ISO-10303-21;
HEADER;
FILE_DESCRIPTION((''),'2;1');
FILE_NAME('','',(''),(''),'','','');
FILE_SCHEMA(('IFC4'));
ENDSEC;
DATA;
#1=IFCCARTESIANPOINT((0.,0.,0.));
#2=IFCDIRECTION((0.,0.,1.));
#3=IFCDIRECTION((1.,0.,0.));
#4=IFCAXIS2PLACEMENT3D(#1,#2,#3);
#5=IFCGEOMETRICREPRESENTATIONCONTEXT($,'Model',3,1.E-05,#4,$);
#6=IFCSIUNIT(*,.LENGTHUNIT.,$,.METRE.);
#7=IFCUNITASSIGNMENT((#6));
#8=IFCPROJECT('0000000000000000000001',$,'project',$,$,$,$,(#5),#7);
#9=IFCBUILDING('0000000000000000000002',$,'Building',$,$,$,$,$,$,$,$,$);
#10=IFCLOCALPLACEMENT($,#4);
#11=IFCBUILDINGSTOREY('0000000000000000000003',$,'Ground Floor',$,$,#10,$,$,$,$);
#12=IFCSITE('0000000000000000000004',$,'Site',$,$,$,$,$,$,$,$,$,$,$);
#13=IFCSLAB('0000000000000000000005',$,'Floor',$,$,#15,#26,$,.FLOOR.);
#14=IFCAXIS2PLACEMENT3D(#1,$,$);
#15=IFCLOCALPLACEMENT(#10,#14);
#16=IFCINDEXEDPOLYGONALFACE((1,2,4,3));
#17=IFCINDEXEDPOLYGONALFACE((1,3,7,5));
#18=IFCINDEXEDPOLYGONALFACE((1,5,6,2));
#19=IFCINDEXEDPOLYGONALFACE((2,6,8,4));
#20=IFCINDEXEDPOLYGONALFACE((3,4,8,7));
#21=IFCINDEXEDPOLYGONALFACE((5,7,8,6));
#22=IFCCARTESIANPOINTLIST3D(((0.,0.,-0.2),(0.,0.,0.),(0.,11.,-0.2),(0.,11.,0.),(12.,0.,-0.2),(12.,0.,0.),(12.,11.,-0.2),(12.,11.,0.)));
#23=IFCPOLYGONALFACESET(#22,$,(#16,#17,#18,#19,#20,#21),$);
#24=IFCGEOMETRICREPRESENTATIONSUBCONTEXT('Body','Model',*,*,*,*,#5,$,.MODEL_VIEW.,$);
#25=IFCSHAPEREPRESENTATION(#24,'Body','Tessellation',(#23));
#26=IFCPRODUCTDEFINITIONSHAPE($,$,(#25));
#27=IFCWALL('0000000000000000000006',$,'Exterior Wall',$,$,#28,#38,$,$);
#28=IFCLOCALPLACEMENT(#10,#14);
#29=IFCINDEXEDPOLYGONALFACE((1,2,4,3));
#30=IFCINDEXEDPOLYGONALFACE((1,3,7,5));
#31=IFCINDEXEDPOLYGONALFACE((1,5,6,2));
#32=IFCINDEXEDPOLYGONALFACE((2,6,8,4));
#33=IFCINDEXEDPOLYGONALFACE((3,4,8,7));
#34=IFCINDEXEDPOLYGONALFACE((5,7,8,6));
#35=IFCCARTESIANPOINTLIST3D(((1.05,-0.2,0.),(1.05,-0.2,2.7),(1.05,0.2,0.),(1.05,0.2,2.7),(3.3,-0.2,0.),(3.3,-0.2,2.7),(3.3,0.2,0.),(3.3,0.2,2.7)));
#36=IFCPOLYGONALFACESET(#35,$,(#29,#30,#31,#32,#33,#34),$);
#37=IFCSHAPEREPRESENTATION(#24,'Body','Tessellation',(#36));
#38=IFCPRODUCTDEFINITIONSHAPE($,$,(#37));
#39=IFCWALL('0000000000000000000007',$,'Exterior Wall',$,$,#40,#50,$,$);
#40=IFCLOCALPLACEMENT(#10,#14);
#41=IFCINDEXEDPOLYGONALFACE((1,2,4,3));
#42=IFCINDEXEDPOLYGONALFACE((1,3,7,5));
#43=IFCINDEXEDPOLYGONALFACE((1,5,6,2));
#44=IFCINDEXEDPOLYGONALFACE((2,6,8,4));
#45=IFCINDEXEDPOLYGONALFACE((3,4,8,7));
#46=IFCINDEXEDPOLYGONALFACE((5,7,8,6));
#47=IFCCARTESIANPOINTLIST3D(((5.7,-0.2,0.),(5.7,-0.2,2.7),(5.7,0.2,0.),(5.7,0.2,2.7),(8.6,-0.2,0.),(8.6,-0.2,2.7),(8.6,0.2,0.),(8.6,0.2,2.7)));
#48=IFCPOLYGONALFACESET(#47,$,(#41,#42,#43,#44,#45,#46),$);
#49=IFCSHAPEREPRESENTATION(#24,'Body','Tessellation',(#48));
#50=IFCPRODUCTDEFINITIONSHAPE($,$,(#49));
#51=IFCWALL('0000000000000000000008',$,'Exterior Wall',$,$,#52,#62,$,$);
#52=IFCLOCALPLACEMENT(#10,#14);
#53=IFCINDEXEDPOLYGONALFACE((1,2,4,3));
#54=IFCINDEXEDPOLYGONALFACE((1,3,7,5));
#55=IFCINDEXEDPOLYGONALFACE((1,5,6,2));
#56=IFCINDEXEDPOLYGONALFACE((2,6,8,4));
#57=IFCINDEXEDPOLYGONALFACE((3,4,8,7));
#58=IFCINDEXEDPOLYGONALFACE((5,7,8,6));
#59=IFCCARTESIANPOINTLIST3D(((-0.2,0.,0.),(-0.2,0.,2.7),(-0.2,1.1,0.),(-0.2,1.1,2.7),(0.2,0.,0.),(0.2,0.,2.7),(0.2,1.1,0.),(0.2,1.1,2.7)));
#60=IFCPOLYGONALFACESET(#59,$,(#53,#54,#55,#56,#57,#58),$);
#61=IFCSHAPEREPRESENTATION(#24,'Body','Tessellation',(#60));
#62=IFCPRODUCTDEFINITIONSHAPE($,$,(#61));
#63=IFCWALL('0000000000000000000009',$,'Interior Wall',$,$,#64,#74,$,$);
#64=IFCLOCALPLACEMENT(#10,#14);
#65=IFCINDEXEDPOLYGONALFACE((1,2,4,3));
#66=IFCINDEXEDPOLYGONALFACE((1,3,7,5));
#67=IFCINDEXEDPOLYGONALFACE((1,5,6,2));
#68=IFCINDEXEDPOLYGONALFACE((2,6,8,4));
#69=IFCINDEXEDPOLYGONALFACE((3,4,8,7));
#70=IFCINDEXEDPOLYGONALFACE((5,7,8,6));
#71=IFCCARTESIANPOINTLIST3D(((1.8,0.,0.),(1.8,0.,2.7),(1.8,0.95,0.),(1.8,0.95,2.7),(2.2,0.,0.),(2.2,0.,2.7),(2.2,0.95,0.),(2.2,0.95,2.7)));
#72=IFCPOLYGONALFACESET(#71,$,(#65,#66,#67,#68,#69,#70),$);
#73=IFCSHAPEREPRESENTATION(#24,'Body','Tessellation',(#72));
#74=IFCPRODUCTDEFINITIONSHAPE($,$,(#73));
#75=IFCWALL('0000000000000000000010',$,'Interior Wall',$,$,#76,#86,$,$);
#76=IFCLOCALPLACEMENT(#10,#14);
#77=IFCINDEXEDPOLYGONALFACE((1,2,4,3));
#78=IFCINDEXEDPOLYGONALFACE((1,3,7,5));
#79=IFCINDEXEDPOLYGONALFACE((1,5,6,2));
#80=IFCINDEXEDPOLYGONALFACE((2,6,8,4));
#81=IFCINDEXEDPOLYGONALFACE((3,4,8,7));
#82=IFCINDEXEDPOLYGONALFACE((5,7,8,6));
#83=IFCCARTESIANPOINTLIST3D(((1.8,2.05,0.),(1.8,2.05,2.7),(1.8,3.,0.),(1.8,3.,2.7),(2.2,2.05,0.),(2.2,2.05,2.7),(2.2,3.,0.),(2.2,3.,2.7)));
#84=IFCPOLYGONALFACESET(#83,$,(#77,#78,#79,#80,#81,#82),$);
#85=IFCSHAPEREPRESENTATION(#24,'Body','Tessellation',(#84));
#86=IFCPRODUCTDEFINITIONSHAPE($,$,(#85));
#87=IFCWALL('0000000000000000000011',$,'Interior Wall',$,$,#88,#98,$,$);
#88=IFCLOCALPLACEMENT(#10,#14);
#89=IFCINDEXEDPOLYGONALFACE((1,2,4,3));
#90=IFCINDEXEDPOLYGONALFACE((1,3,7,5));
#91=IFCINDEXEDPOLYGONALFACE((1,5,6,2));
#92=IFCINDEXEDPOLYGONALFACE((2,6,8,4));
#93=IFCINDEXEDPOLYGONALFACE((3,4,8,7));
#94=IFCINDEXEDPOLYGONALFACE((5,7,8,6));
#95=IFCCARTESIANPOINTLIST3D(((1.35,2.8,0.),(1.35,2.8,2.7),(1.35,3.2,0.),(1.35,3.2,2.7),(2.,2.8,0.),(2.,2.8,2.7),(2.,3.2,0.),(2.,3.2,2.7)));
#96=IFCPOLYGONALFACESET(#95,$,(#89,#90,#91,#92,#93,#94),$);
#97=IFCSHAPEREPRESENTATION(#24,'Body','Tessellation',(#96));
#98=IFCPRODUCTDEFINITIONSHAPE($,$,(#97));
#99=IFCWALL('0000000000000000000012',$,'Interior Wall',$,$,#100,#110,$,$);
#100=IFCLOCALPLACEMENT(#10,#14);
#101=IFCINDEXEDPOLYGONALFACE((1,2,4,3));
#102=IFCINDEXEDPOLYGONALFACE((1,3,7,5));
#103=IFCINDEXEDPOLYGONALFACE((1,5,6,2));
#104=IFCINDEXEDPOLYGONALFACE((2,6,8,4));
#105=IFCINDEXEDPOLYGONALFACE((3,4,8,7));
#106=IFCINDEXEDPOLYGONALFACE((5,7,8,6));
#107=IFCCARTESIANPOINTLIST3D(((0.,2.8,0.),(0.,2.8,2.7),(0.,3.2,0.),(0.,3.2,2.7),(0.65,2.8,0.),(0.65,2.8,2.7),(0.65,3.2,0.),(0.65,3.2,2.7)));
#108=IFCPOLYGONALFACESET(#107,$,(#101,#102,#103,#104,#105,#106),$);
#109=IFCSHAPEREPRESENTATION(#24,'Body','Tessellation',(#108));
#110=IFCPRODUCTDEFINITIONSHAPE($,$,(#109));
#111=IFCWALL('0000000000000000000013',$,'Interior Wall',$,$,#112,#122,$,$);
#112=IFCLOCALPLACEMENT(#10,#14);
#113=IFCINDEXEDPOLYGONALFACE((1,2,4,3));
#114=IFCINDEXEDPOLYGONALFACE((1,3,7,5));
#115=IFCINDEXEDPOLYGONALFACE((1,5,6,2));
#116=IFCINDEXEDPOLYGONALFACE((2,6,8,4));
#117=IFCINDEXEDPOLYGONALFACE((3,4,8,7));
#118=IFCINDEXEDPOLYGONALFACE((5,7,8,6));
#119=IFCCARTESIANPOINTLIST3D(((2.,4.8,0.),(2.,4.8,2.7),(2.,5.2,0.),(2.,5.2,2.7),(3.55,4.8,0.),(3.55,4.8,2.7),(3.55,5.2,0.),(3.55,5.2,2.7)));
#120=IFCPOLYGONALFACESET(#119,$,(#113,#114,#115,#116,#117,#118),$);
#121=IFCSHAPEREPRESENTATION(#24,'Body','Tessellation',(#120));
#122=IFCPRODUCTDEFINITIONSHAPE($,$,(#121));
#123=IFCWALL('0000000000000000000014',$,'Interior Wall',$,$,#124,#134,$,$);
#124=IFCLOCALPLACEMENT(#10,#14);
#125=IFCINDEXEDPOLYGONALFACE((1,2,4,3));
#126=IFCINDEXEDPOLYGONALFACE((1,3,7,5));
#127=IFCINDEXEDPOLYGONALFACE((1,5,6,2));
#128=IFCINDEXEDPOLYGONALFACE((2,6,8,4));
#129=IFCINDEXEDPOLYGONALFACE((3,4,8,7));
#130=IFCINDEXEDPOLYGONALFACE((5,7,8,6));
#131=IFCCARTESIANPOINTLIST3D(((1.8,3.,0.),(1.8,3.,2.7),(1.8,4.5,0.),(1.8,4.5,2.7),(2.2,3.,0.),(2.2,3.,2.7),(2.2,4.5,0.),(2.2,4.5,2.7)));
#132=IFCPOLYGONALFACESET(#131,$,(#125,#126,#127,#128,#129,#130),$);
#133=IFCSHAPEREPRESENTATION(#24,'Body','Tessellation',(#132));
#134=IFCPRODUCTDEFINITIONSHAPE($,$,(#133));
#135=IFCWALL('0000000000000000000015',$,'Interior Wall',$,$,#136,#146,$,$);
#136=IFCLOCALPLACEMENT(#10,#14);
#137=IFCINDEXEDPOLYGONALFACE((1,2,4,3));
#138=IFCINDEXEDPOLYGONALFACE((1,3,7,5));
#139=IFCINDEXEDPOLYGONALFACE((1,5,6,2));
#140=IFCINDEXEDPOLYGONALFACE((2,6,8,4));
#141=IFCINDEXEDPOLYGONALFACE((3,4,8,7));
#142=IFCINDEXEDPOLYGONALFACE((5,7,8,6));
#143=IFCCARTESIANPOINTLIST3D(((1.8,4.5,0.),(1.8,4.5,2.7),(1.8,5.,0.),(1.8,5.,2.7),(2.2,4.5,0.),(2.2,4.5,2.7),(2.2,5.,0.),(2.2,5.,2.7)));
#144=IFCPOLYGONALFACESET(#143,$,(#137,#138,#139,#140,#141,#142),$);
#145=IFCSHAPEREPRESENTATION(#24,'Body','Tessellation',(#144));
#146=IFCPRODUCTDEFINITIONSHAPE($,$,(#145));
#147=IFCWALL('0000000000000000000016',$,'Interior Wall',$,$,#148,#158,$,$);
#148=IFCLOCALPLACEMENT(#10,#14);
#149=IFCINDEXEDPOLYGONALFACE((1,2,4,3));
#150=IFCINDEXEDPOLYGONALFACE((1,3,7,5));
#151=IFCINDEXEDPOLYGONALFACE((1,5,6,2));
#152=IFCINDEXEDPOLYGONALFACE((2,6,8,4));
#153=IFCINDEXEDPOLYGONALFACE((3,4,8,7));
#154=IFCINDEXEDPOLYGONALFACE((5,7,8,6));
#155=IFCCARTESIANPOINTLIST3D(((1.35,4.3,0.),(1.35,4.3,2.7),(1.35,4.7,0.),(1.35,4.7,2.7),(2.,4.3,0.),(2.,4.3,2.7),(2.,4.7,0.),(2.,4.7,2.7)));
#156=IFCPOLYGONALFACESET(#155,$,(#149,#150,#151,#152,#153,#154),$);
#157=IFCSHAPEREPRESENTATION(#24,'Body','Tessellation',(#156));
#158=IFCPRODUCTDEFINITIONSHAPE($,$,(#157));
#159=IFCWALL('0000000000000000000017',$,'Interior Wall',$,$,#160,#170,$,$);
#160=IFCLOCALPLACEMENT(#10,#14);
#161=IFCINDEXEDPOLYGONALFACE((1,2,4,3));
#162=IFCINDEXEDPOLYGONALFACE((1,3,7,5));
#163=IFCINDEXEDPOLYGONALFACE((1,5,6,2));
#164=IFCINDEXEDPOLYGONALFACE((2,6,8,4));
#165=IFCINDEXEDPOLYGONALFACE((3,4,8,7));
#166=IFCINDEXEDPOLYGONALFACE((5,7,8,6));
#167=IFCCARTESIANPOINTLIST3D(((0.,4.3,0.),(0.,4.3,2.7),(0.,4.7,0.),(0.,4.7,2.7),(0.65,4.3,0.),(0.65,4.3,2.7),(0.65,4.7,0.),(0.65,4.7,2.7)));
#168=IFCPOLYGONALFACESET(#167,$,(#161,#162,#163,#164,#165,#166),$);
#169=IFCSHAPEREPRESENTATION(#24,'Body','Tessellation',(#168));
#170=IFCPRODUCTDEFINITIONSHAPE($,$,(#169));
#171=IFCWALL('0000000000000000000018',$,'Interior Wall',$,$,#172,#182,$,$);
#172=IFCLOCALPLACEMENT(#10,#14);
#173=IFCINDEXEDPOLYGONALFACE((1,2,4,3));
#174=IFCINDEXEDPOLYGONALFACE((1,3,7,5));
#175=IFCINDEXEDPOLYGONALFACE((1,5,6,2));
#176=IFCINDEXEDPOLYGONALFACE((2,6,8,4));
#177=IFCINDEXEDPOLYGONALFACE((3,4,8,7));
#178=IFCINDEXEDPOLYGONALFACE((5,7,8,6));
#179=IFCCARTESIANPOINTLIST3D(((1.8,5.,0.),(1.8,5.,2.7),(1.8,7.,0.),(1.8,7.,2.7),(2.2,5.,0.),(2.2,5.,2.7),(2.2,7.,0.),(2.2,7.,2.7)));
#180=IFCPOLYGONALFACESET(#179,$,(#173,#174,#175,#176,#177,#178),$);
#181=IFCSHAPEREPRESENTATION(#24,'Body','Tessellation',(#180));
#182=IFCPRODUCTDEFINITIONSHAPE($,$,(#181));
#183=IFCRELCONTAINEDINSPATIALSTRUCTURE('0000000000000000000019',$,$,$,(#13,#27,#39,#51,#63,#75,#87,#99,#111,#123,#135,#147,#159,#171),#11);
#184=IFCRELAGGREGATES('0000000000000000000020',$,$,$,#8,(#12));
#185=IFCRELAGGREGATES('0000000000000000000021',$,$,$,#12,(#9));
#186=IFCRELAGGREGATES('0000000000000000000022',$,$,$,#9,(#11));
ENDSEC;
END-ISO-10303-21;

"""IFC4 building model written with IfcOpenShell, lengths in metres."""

from ifc_helpers import new_model, si_unit, frame, origin_with_axes, place, context, subcontext, project, spatial, indexed_curve, outline, extrude, element, save


model = new_model("IFC4")

# Units and contexts
model_context = context("Model", 3, precision=1e-05, world=origin_with_axes())
body_context = subcontext(model_context, "Body", "Model", "MODEL_VIEW")
ifc_project = project(units=[si_unit("LENGTHUNIT", "METRE")], contexts=[model_context])

# Site, building, storey
site = spatial("IfcSite", under=ifc_project, Name="Site")
building = spatial("IfcBuilding", under=site, Name="Building")
storey_placement = place(None, origin_with_axes())
storey = spatial("IfcBuildingStorey", under=building, at=storey_placement, Name="Ground Floor")

# Slab
slab_placement = place(storey_placement, frame((0.0, 0.0, -0.2), z_axis=(0.0, 0.0, 1.0), x_axis=(1.0, 0.0, 0.0)))
element("IfcSlab", 1, at=slab_placement, inside=storey, Name="Floor", PredefinedType="FLOOR", context=body_context, shape_type="SweptSolid", body=[
    extrude(outline(indexed_curve([(0.0, 0.0), (12.0, 0.0), (12.0, 11.0), (0.0, 11.0)])), None, (0.0, 0.0, 1.0), 0.2),
])

# Walls
wall_1_placement = place(storey_placement, frame((1.05, 0.0, 0.0), z_axis=(0.0, 0.0, 1.0), x_axis=(1.0, 0.0, 0.0)))
element("IfcWall", 2, at=wall_1_placement, inside=storey, Name="Exterior Wall", context=body_context, shape_type="SweptSolid", body=[
    extrude(outline(indexed_curve([(0.0, 0.0), (0.0, 0.4), (2.25, 0.4), (2.25, 0.0), (0.0, 0.0)], self_intersect=False)), frame((0.0, -0.2, 0.0), z_axis=(0.0, 0.0, 1.0), x_axis=(1.0, 0.0, 0.0)), (0.0, 0.0, 1.0), 2.7),
])
wall_2_placement = place(storey_placement, frame((5.7, 0.0, 0.0), z_axis=(0.0, 0.0, 1.0), x_axis=(1.0, 0.0, 0.0)))
element("IfcWall", 3, at=wall_2_placement, inside=storey, Name="Exterior Wall", context=body_context, shape_type="SweptSolid", body=[
    extrude(outline(indexed_curve([(0.0, 0.0), (0.0, 0.4), (2.9, 0.4), (2.9, 0.0), (0.0, 0.0)], self_intersect=False)), frame((0.0, -0.2, 0.0), z_axis=(0.0, 0.0, 1.0), x_axis=(1.0, 0.0, 0.0)), (0.0, 0.0, 1.0), 2.7),
])
wall_3_placement = place(storey_placement, frame((0.0, 1.1, 0.0), z_axis=(0.0, 0.0, 1.0), x_axis=(0.0, -1.0, 0.0)))
element("IfcWall", 4, at=wall_3_placement, inside=storey, Name="Exterior Wall", context=body_context, shape_type="SweptSolid", body=[
    extrude(outline(indexed_curve([(0.0, 0.0), (0.0, 0.4), (1.1, 0.4), (1.1, 0.0), (0.0, 0.0)], self_intersect=False)), frame((0.0, -0.2, 0.0), z_axis=(0.0, 0.0, 1.0), x_axis=(1.0, 0.0, 0.0)), (0.0, 0.0, 1.0), 2.7),
])
wall_4_placement = place(storey_placement, frame((2.0, 0.0, 0.0), z_axis=(0.0, 0.0, 1.0), x_axis=(0.0, 1.0, 0.0)))
element("IfcWall", 5, at=wall_4_placement, inside=storey, Name="Interior Wall", context=body_context, shape_type="SweptSolid", body=[
    extrude(outline(indexed_curve([(0.0, 0.0), (0.0, 0.4), (0.95, 0.4), (0.95, 0.0), (0.0, 0.0)], self_intersect=False)), frame((0.0, -0.2, 0.0), z_axis=(0.0, 0.0, 1.0), x_axis=(1.0, 0.0, 0.0)), (0.0, 0.0, 1.0), 2.7),
])
wall_5_placement = place(storey_placement, frame((2.0, 2.05, 0.0), z_axis=(0.0, 0.0, 1.0), x_axis=(0.0, 1.0, 0.0)))
element("IfcWall", 6, at=wall_5_placement, inside=storey, Name="Interior Wall", context=body_context, shape_type="SweptSolid", body=[
    extrude(outline(indexed_curve([(0.0, 0.0), (0.0, 0.4), (0.95, 0.4), (0.95, 0.0), (0.0, 0.0)], self_intersect=False)), frame((0.0, -0.2, 0.0), z_axis=(0.0, 0.0, 1.0), x_axis=(1.0, 0.0, 0.0)), (0.0, 0.0, 1.0), 2.7),
])
for number, where, z_axis, x_axis, name in (
    (7, (2.0, 3.0, 0.0), (0.0, 0.0, 1.0), (-1.0, 0.0, 0.0), "Interior Wall"),
    (8, (0.65, 3.0, 0.0), (0.0, 0.0, 1.0), (-1.0, 0.0, 0.0), "Interior Wall"),
):
    element("IfcWall", number, at=place(storey_placement, frame(where, z_axis=z_axis, x_axis=x_axis)), inside=storey, Name=name, context=body_context, shape_type="SweptSolid", body=[
        extrude(outline(indexed_curve([(0.0, 0.0), (0.0, 0.4), (0.65, 0.4), (0.65, 0.0), (0.0, 0.0)], self_intersect=False)), frame((0.0, -0.2, 0.0), z_axis=(0.0, 0.0, 1.0), x_axis=(1.0, 0.0, 0.0)), (0.0, 0.0, 1.0), 2.7),
    ])
wall_6_placement = place(storey_placement, frame((3.55, 5.0, 0.0), z_axis=(0.0, 0.0, 1.0), x_axis=(-1.0, 0.0, 0.0)))
element("IfcWall", 9, at=wall_6_placement, inside=storey, Name="Interior Wall", context=body_context, shape_type="SweptSolid", body=[
    extrude(outline(indexed_curve([(0.0, 0.0), (0.0, 0.4), (1.55, 0.4), (1.55, 0.0), (0.0, 0.0)], self_intersect=False)), frame((0.0, -0.2, 0.0), z_axis=(0.0, 0.0, 1.0), x_axis=(1.0, 0.0, 0.0)), (0.0, 0.0, 1.0), 2.7),
])
wall_7_placement = place(storey_placement, frame((2.0, 4.5, 0.0), z_axis=(0.0, 0.0, 1.0), x_axis=(0.0, -1.0, 0.0)))
element("IfcWall", 10, at=wall_7_placement, inside=storey, Name="Interior Wall", context=body_context, shape_type="SweptSolid", body=[
    extrude(outline(indexed_curve([(0.0, 0.0), (0.0, 0.4), (1.5, 0.4), (1.5, 0.0), (0.0, 0.0)], self_intersect=False)), frame((0.0, -0.2, 0.0), z_axis=(0.0, 0.0, 1.0), x_axis=(1.0, 0.0, 0.0)), (0.0, 0.0, 1.0), 2.7),
])
wall_8_placement = place(storey_placement, frame((2.0, 5.0, 0.0), z_axis=(0.0, 0.0, 1.0), x_axis=(0.0, -1.0, 0.0)))
element("IfcWall", 11, at=wall_8_placement, inside=storey, Name="Interior Wall", context=body_context, shape_type="SweptSolid", body=[
    extrude(outline(indexed_curve([(0.0, 0.0), (0.0, 0.4), (0.5, 0.4), (0.5, 0.0), (0.0, 0.0)], self_intersect=False)), frame((0.0, -0.2, 0.0), z_axis=(0.0, 0.0, 1.0), x_axis=(1.0, 0.0, 0.0)), (0.0, 0.0, 1.0), 2.7),
])
for number, where, z_axis, x_axis, name in (
    (12, (2.0, 4.5, 0.0), (0.0, 0.0, 1.0), (-1.0, 0.0, 0.0), "Interior Wall"),
    (13, (0.65, 4.5, 0.0), (0.0, 0.0, 1.0), (-1.0, 0.0, 0.0), "Interior Wall"),
):
    element("IfcWall", number, at=place(storey_placement, frame(where, z_axis=z_axis, x_axis=x_axis)), inside=storey, Name=name, context=body_context, shape_type="SweptSolid", body=[
        extrude(outline(indexed_curve([(0.0, 0.0), (0.0, 0.4), (0.65, 0.4), (0.65, 0.0), (0.0, 0.0)], self_intersect=False)), frame((0.0, -0.2, 0.0), z_axis=(0.0, 0.0, 1.0), x_axis=(1.0, 0.0, 0.0)), (0.0, 0.0, 1.0), 2.7),
    ])
wall_9_placement = place(storey_placement, frame((2.0, 5.0, 0.0), z_axis=(0.0, 0.0, 1.0), x_axis=(0.0, 1.0, 0.0)))
element("IfcWall", 14, at=wall_9_placement, inside=storey, Name="Interior Wall", context=body_context, shape_type="SweptSolid", body=[
    extrude(outline(indexed_curve([(0.0, 0.0), (0.0, 0.4), (2.0, 0.4), (2.0, 0.0), (0.0, 0.0)], self_intersect=False)), frame((0.0, -0.2, 0.0), z_axis=(0.0, 0.0, 1.0), x_axis=(1.0, 0.0, 0.0)), (0.0, 0.0, 1.0), 2.7),
])

save(model, "model.ifc")
